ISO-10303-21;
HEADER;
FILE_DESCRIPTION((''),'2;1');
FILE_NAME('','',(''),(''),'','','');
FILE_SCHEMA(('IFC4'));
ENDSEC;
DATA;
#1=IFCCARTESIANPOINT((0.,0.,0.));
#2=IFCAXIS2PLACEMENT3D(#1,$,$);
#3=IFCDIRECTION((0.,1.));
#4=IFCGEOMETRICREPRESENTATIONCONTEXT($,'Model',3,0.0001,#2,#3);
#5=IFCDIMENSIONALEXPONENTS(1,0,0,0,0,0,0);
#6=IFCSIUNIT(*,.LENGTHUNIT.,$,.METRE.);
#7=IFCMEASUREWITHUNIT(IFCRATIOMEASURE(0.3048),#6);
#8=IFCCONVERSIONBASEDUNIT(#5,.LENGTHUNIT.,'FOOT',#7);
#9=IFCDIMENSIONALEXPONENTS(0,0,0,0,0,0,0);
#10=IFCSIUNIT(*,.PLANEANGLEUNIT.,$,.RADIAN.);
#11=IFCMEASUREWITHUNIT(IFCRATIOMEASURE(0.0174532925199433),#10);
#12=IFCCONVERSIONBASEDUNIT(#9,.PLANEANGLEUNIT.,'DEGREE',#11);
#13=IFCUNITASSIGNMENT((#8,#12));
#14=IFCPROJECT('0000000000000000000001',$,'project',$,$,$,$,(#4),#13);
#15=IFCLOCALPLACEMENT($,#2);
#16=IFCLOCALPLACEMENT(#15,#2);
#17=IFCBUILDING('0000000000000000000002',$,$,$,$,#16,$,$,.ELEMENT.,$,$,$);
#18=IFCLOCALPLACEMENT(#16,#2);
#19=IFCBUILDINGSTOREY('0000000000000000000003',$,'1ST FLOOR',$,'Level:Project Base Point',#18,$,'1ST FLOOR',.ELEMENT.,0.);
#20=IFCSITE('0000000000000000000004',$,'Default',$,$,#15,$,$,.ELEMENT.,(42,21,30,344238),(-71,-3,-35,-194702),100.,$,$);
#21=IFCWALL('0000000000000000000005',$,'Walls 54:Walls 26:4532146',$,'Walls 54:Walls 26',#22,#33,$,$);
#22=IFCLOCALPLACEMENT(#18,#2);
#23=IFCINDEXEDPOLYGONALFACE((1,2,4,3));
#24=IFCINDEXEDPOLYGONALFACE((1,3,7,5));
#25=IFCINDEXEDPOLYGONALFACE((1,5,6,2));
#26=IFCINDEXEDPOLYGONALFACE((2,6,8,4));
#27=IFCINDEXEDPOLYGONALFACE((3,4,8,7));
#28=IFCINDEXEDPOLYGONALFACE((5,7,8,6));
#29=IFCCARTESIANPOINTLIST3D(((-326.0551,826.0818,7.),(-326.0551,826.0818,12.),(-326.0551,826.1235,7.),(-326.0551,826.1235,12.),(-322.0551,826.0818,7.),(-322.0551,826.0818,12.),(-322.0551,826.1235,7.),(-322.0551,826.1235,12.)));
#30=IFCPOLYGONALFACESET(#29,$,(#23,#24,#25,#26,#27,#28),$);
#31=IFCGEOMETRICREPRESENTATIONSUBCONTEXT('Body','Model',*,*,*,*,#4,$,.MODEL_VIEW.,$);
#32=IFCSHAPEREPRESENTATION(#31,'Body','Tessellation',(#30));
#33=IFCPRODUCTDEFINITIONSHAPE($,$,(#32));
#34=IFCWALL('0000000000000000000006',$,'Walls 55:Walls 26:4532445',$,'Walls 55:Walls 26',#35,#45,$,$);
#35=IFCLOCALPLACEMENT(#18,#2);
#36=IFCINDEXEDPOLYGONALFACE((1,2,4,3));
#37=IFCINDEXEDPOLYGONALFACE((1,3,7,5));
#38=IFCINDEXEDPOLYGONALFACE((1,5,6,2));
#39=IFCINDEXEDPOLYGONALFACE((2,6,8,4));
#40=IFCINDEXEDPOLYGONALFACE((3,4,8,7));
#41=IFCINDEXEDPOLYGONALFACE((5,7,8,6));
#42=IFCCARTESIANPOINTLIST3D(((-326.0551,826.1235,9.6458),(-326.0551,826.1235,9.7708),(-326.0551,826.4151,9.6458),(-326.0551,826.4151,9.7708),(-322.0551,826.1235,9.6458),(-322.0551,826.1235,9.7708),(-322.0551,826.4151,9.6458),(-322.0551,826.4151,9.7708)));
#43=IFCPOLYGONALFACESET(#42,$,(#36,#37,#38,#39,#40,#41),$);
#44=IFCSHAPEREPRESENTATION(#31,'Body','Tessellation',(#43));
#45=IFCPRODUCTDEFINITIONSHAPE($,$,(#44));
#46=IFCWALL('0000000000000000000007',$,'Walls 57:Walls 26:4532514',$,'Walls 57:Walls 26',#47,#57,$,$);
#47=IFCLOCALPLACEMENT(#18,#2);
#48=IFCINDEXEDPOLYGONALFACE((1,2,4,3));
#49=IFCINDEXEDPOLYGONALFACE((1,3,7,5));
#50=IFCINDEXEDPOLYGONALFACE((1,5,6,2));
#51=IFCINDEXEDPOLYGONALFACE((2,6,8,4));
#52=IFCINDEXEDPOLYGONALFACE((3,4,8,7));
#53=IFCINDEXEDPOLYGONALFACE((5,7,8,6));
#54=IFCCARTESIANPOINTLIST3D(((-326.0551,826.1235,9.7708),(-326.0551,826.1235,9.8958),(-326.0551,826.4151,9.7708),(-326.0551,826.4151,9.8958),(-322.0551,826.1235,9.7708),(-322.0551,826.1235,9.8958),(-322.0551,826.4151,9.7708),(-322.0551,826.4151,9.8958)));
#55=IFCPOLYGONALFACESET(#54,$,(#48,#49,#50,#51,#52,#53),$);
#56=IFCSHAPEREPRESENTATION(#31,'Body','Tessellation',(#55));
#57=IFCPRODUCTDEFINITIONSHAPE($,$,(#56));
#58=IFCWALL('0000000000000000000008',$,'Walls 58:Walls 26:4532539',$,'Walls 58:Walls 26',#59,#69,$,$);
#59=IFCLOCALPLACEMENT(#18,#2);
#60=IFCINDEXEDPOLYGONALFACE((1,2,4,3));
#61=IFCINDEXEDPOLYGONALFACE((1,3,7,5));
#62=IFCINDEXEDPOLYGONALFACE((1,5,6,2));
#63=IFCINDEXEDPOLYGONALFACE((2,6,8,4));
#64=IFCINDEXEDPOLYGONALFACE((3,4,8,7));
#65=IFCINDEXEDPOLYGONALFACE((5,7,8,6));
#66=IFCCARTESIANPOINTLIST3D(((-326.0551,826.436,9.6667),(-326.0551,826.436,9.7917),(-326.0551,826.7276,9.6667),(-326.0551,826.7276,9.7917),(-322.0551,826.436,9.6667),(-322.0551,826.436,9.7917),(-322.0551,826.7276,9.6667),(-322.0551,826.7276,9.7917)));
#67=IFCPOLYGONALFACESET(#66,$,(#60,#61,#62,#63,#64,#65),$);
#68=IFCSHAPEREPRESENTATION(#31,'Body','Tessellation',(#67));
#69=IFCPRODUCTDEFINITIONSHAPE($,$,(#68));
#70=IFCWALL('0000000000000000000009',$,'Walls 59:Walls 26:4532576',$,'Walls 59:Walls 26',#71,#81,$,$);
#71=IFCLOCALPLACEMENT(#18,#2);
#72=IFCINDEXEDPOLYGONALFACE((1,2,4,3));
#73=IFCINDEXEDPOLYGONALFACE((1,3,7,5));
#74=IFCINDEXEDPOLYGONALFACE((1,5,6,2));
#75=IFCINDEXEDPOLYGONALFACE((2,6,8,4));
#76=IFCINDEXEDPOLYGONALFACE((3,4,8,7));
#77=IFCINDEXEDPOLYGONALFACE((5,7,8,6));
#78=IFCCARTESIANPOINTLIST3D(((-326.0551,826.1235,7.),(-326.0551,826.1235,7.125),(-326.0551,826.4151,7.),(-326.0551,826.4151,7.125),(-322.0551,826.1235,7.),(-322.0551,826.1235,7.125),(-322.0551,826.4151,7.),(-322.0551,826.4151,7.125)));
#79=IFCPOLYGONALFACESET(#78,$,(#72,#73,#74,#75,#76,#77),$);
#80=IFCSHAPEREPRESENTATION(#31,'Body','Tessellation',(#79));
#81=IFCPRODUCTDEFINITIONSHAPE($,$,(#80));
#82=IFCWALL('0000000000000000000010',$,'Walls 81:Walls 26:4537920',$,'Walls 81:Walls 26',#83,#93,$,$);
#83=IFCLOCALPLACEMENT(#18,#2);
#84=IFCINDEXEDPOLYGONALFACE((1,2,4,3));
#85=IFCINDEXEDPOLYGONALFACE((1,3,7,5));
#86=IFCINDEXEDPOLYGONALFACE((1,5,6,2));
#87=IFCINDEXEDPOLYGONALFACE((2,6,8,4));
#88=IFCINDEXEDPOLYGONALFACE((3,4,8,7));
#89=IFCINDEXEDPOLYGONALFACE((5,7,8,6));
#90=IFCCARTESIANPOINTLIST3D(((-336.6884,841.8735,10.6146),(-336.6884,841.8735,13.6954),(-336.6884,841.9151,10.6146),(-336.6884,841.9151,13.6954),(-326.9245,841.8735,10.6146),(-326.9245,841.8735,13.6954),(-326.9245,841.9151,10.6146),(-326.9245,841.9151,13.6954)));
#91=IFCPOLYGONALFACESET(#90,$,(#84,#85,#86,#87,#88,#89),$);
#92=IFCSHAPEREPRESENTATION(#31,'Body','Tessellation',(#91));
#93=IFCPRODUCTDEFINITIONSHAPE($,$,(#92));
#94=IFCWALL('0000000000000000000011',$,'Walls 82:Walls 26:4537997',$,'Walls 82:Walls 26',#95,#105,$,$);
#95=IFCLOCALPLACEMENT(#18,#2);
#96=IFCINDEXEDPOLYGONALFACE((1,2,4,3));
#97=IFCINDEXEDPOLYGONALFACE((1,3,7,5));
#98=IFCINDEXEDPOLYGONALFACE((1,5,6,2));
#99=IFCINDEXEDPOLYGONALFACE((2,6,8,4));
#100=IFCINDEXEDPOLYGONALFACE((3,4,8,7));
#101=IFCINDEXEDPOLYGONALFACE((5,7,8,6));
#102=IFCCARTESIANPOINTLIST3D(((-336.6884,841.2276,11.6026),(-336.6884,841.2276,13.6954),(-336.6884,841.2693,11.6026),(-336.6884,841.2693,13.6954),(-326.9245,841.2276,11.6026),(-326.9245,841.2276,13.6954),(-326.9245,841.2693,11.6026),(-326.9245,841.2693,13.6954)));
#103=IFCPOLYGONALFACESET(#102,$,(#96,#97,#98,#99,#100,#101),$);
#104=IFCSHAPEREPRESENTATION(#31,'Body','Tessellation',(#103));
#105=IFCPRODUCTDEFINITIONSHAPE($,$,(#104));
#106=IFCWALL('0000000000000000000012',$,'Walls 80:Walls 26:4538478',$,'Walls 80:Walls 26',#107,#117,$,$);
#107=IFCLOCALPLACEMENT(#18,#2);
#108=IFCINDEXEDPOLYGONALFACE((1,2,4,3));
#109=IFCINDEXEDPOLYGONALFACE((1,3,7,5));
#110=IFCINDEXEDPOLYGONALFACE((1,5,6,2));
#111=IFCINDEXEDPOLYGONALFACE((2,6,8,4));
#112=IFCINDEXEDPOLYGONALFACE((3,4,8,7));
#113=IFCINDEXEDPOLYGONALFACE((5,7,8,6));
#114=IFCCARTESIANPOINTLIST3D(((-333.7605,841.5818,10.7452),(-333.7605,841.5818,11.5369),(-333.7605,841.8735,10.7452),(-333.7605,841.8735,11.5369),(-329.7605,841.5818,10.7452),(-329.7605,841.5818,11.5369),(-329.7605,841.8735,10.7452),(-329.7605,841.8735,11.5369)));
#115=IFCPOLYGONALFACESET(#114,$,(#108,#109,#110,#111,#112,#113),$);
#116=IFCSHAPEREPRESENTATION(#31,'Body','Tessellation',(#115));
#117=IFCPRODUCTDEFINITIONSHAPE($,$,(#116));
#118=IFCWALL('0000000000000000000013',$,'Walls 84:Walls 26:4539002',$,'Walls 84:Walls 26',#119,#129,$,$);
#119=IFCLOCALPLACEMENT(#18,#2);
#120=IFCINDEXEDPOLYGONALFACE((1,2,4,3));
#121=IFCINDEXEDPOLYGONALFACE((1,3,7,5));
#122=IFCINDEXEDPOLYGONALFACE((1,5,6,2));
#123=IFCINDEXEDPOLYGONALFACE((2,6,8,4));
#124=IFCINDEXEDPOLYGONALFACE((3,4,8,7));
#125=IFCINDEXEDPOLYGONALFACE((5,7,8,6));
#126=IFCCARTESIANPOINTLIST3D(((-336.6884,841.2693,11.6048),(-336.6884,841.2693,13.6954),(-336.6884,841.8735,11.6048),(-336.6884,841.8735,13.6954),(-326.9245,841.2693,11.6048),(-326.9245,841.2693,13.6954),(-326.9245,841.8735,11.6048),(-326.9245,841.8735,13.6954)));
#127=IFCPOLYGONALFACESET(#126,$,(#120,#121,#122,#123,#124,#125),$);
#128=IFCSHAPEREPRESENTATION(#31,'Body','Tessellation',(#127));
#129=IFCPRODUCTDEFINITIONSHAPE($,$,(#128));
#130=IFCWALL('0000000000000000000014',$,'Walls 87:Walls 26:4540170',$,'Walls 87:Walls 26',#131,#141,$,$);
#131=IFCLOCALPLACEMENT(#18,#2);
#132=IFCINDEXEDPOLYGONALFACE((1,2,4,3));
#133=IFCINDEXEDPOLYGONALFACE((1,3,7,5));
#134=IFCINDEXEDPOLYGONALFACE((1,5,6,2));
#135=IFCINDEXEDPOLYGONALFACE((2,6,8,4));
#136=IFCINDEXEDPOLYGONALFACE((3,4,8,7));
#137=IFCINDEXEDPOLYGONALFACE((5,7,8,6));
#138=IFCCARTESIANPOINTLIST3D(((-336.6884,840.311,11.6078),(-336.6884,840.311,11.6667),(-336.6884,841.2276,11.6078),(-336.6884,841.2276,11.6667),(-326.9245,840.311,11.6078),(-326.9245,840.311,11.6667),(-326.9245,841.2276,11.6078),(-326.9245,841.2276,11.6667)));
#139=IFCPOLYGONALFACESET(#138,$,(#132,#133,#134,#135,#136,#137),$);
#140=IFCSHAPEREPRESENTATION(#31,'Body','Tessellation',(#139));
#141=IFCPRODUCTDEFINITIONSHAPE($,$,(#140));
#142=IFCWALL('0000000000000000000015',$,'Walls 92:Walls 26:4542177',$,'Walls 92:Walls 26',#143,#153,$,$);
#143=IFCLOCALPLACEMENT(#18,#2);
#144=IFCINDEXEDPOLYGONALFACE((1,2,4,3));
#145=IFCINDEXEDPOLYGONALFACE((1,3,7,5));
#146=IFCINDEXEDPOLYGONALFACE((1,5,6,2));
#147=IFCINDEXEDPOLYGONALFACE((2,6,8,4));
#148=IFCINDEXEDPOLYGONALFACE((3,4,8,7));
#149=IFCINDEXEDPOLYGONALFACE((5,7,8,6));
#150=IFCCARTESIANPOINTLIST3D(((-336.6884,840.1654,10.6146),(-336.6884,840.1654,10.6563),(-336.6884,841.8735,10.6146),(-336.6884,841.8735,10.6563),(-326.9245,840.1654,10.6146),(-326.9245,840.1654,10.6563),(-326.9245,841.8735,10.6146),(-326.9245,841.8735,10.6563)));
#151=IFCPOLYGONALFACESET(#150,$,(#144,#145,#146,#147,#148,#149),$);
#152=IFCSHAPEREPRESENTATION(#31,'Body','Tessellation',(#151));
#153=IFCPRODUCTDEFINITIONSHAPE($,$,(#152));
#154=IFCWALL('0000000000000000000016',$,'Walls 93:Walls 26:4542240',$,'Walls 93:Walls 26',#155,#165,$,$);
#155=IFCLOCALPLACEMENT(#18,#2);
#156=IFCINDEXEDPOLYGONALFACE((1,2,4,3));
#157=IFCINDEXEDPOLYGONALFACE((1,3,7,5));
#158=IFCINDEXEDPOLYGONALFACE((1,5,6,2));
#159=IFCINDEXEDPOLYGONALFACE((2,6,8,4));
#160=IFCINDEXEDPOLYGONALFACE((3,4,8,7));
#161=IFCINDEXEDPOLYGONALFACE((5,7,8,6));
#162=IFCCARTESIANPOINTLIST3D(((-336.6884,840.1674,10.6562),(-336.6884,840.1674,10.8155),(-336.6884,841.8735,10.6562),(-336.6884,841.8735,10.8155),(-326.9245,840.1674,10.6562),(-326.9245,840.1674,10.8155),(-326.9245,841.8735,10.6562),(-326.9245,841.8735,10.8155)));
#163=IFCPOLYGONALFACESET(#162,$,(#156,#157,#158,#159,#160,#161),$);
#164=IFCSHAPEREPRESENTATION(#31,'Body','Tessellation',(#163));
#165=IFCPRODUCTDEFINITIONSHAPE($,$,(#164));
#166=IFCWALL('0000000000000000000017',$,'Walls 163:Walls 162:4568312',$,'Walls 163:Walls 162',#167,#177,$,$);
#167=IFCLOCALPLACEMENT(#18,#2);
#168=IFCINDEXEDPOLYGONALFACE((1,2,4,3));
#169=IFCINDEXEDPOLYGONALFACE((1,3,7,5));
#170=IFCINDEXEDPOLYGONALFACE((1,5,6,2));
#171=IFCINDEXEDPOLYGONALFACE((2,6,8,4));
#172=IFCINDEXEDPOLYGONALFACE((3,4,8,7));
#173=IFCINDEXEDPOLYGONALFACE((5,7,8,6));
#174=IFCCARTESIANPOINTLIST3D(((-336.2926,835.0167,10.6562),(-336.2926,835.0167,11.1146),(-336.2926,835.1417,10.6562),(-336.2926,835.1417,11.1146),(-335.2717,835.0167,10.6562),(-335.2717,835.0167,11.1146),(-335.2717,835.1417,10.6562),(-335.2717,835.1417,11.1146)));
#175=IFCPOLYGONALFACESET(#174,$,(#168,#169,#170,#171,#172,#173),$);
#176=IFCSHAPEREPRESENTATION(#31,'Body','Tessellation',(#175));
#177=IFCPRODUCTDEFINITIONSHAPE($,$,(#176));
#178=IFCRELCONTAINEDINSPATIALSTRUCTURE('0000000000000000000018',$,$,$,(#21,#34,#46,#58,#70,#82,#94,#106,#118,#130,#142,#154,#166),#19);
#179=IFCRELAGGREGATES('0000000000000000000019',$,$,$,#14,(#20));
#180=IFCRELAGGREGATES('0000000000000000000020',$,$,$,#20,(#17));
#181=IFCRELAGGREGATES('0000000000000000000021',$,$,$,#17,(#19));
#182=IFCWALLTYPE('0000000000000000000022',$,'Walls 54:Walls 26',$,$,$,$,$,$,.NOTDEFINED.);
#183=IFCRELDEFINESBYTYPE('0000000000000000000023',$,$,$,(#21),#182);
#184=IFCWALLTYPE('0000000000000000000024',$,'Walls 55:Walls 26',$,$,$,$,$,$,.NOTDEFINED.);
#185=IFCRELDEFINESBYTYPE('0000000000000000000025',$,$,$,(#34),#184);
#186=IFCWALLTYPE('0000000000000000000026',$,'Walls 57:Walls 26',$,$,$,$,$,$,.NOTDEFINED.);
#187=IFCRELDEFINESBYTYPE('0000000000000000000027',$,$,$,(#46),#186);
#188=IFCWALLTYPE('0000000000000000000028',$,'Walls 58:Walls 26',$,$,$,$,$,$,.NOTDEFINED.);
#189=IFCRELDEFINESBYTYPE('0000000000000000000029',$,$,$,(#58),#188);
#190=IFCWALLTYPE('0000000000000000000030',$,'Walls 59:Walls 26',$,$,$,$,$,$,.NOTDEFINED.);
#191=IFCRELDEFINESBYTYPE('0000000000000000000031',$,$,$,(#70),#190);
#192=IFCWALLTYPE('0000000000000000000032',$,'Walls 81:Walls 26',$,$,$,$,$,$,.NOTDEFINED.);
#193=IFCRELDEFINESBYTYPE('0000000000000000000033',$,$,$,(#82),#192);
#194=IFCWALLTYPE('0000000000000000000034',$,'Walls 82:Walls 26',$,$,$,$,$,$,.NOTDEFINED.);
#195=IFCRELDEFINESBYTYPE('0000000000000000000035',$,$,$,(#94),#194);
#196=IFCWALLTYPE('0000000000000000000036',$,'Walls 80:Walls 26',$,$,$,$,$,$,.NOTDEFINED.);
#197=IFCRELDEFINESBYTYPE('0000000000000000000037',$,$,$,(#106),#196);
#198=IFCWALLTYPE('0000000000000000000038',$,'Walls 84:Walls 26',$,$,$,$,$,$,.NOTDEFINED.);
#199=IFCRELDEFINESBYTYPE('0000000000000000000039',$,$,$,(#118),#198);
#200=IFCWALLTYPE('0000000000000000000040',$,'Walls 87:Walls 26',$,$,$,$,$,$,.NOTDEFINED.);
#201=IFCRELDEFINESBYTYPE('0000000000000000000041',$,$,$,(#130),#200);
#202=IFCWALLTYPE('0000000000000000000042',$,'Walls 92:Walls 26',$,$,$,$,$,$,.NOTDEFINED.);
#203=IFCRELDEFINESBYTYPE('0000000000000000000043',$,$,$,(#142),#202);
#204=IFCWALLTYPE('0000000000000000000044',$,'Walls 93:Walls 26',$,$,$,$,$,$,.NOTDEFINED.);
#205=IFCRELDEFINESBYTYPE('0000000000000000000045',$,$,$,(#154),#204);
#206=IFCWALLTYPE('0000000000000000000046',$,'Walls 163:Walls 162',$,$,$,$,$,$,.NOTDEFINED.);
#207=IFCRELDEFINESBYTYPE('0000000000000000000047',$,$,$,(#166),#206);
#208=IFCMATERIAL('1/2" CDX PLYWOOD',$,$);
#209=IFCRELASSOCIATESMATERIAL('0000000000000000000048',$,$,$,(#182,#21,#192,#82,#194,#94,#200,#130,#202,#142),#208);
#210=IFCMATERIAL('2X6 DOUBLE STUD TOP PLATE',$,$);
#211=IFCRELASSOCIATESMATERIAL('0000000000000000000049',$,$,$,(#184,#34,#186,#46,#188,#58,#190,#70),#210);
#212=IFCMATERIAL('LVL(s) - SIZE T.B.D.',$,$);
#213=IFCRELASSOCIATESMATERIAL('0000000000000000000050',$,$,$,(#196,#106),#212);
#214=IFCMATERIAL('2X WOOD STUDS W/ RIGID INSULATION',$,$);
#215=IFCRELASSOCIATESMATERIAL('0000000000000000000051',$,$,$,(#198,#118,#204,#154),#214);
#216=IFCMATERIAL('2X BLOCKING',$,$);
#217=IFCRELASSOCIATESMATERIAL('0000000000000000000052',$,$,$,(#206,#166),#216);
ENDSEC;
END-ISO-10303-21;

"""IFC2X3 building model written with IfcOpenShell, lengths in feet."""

from ifc_helpers import new_model, entity, si_unit, converted_unit, direction, frame, frame_2d, origin, origin_2d_with_axis, place, context, subcontext, project, spatial, rectangle, extrude, material, type_object, element, save


model = new_model("IFC2X3")

# Units and contexts
model_context = context("Model", 3, precision=0.0001, world=origin(), true_north=direction((0.0, 1.0)))
body_context = subcontext(model_context, "Body", "Model", "MODEL_VIEW")
ifc_project = project(units=[converted_unit("LENGTHUNIT", "FOOT", entity("IfcRatioMeasure", 0.3048), si_unit("LENGTHUNIT", "METRE"), dimensions=[1, 0, 0, 0, 0, 0, 0]), converted_unit("PLANEANGLEUNIT", "DEGREE", entity("IfcRatioMeasure", 0.0174532925199433), si_unit("PLANEANGLEUNIT", "RADIAN"), dimensions=[0, 0, 0, 0, 0, 0, 0])], contexts=[model_context])

# Site, building, storey
site_placement = place(None, origin())
site = spatial("IfcSite", under=ifc_project, at=site_placement, Name="Default", CompositionType="ELEMENT", RefLatitude=(42, 21, 30, 344238), RefLongitude=(-71, -3, -35, -194702), RefElevation=100.0)
building_placement = place(site_placement, origin())
building = spatial("IfcBuilding", under=site, at=building_placement, CompositionType="ELEMENT")
storey_placement = place(building_placement, origin())
storey = spatial("IfcBuildingStorey", under=building, at=storey_placement, Name="1ST FLOOR", ObjectType="Level:Project Base Point", LongName="1ST FLOOR", CompositionType="ELEMENT", Elevation=0.0)

# Walls
ifc_material_1 = material(Name="1/2\" CDX PLYWOOD")
wall_type_1 = type_object("IfcWallType", Name="Walls 54:Walls 26", PredefinedType="NOTDEFINED", material=ifc_material_1)
wall_1_placement = place(storey_placement, frame((-326.0551, 826.0818, 7.0)))
element("IfcWall", 1, at=wall_1_placement, inside=storey, type_object=wall_type_1, material=ifc_material_1, Name="Walls 54:Walls 26:4532146", ObjectType="Walls 54:Walls 26", context=body_context, shape_type="SweptSolid", body=[
    extrude(rectangle(XDim=4.0, YDim=0.0417, at=frame_2d((0.0, 0.0), x_axis=(1.0, 0.0))), frame((2.0, 0.0208, 0.0), z_axis=(0.0, 0.0, 1.0), x_axis=(-1.0, 0.0, 0.0)), (0.0, 0.0, 1.0), 5.0),
])
ifc_material_2 = material(Name="2X6 DOUBLE STUD TOP PLATE")
wall_type_2 = type_object("IfcWallType", Name="Walls 55:Walls 26", PredefinedType="NOTDEFINED", material=ifc_material_2)
wall_2_placement = place(storey_placement, frame((-326.0551, 826.1235, 9.6458)))
element("IfcWall", 2, at=wall_2_placement, inside=storey, type_object=wall_type_2, material=ifc_material_2, Name="Walls 55:Walls 26:4532445", ObjectType="Walls 55:Walls 26", context=body_context, shape_type="SweptSolid", body=[
    extrude(rectangle(XDim=4.0, YDim=0.2917, at=origin_2d_with_axis()), frame((2.0, 0.1458, 0.0), z_axis=(0.0, 0.0, 1.0), x_axis=(-1.0, 0.0, 0.0)), (0.0, 0.0, 1.0), 0.125),
])
wall_type_3 = type_object("IfcWallType", Name="Walls 57:Walls 26", PredefinedType="NOTDEFINED", material=ifc_material_2)
wall_3_placement = place(storey_placement, frame((-326.0551, 826.1235, 9.7708)))
element("IfcWall", 3, at=wall_3_placement, inside=storey, type_object=wall_type_3, material=ifc_material_2, Name="Walls 57:Walls 26:4532514", ObjectType="Walls 57:Walls 26", context=body_context, shape_type="SweptSolid", body=[
    extrude(rectangle(XDim=4.0, YDim=0.2917, at=origin_2d_with_axis()), frame((2.0, 0.1458, 0.0), z_axis=(0.0, 0.0, 1.0), x_axis=(-1.0, 0.0, 0.0)), (0.0, 0.0, 1.0), 0.125),
])
wall_type_4 = type_object("IfcWallType", Name="Walls 58:Walls 26", PredefinedType="NOTDEFINED", material=ifc_material_2)
wall_4_placement = place(storey_placement, frame((-326.0551, 826.436, 9.6667)))
element("IfcWall", 4, at=wall_4_placement, inside=storey, type_object=wall_type_4, material=ifc_material_2, Name="Walls 58:Walls 26:4532539", ObjectType="Walls 58:Walls 26", context=body_context, shape_type="SweptSolid", body=[
    extrude(rectangle(XDim=4.0, YDim=0.2917, at=origin_2d_with_axis()), frame((2.0, 0.1458, 0.0), z_axis=(0.0, 0.0, 1.0), x_axis=(-1.0, 0.0, 0.0)), (0.0, 0.0, 1.0), 0.125),
])
wall_type_5 = type_object("IfcWallType", Name="Walls 59:Walls 26", PredefinedType="NOTDEFINED", material=ifc_material_2)
wall_5_placement = place(storey_placement, frame((-326.0551, 826.1235, 7.0)))
element("IfcWall", 5, at=wall_5_placement, inside=storey, type_object=wall_type_5, material=ifc_material_2, Name="Walls 59:Walls 26:4532576", ObjectType="Walls 59:Walls 26", context=body_context, shape_type="SweptSolid", body=[
    extrude(rectangle(XDim=4.0, YDim=0.2917, at=origin_2d_with_axis()), frame((2.0, 0.1458, 0.0), z_axis=(0.0, 0.0, 1.0), x_axis=(-1.0, 0.0, 0.0)), (0.0, 0.0, 1.0), 0.125),
])
wall_type_6 = type_object("IfcWallType", Name="Walls 81:Walls 26", PredefinedType="NOTDEFINED", material=ifc_material_1)
wall_6_placement = place(storey_placement, frame((-336.6884, 841.8735, 10.6146)))
element("IfcWall", 6, at=wall_6_placement, inside=storey, type_object=wall_type_6, material=ifc_material_1, Name="Walls 81:Walls 26:4537920", ObjectType="Walls 81:Walls 26", context=body_context, shape_type="SweptSolid", body=[
    extrude(rectangle(XDim=9.7639, YDim=0.0417, at=frame_2d((0.0, 0.0), x_axis=(1.0, 0.0))), frame((4.882, 0.0208, 0.0), z_axis=(0.0, 0.0, 1.0), x_axis=(-1.0, 0.0, 0.0)), (0.0, 0.0, 1.0), 3.0808),
])
wall_type_7 = type_object("IfcWallType", Name="Walls 82:Walls 26", PredefinedType="NOTDEFINED", material=ifc_material_1)
wall_7_placement = place(storey_placement, frame((-336.6884, 841.2276, 11.6026)))
element("IfcWall", 7, at=wall_7_placement, inside=storey, type_object=wall_type_7, material=ifc_material_1, Name="Walls 82:Walls 26:4537997", ObjectType="Walls 82:Walls 26", context=body_context, shape_type="SweptSolid", body=[
    extrude(rectangle(XDim=9.7639, YDim=0.0417, at=frame_2d((0.0, 0.0), x_axis=(1.0, 0.0))), frame((4.882, 0.0208, 0.0), z_axis=(0.0, 0.0, 1.0), x_axis=(-1.0, 0.0, 0.0)), (0.0, 0.0, 1.0), 2.0927),
])
ifc_material_3 = material(Name="LVL(s) - SIZE T.B.D.")
wall_type_8 = type_object("IfcWallType", Name="Walls 80:Walls 26", PredefinedType="NOTDEFINED", material=ifc_material_3)
wall_8_placement = place(storey_placement, frame((-333.7605, 841.5818, 10.7452)))
element("IfcWall", 8, at=wall_8_placement, inside=storey, type_object=wall_type_8, material=ifc_material_3, Name="Walls 80:Walls 26:4538478", ObjectType="Walls 80:Walls 26", context=body_context, shape_type="SweptSolid", body=[
    extrude(rectangle(XDim=4.0, YDim=0.2917, at=frame_2d((0.0, 0.0), x_axis=(1.0, 0.0))), frame((2.0, 0.1458, 0.0), z_axis=(0.0, 0.0, 1.0), x_axis=(-1.0, 0.0, 0.0)), (0.0, 0.0, 1.0), 0.7917),
])
ifc_material_4 = material(Name="2X WOOD STUDS W/ RIGID INSULATION")
wall_type_9 = type_object("IfcWallType", Name="Walls 84:Walls 26", PredefinedType="NOTDEFINED", material=ifc_material_4)
wall_9_placement = place(storey_placement, frame((-336.6884, 841.2693, 11.6048)))
element("IfcWall", 9, at=wall_9_placement, inside=storey, type_object=wall_type_9, material=ifc_material_4, Name="Walls 84:Walls 26:4539002", ObjectType="Walls 84:Walls 26", context=body_context, shape_type="SweptSolid", body=[
    extrude(rectangle(XDim=9.7639, YDim=0.6042, at=origin_2d_with_axis()), frame((4.882, 0.3021, 0.0), z_axis=(0.0, 0.0, 1.0), x_axis=(-1.0, 0.0, 0.0)), (0.0, 0.0, 1.0), 2.0906),
])
wall_type_10 = type_object("IfcWallType", Name="Walls 87:Walls 26", PredefinedType="NOTDEFINED", material=ifc_material_1)
wall_10_placement = place(storey_placement, frame((-336.6884, 840.311, 11.6078)))
element("IfcWall", 10, at=wall_10_placement, inside=storey, type_object=wall_type_10, material=ifc_material_1, Name="Walls 87:Walls 26:4540170", ObjectType="Walls 87:Walls 26", context=body_context, shape_type="SweptSolid", body=[
    extrude(rectangle(XDim=9.7639, YDim=0.9167, at=frame_2d((0.0, 0.0), x_axis=(1.0, 0.0))), frame((4.882, 0.4583, 0.0), z_axis=(0.0, 0.0, 1.0), x_axis=(-1.0, 0.0, 0.0)), (0.0, 0.0, 1.0), 0.0588),
])
wall_type_11 = type_object("IfcWallType", Name="Walls 92:Walls 26", PredefinedType="NOTDEFINED", material=ifc_material_1)
wall_11_placement = place(storey_placement, frame((-336.6884, 840.1654, 10.6146)))
element("IfcWall", 11, at=wall_11_placement, inside=storey, type_object=wall_type_11, material=ifc_material_1, Name="Walls 92:Walls 26:4542177", ObjectType="Walls 92:Walls 26", context=body_context, shape_type="SweptSolid", body=[
    extrude(rectangle(XDim=9.7639, YDim=1.708, at=origin_2d_with_axis()), frame((4.882, 0.854, 0.0), z_axis=(0.0, 0.0, 1.0), x_axis=(-1.0, 0.0, 0.0)), (0.0, 0.0, 1.0), 0.0417),
])
wall_type_12 = type_object("IfcWallType", Name="Walls 93:Walls 26", PredefinedType="NOTDEFINED", material=ifc_material_4)
wall_12_placement = place(storey_placement, frame((-336.6884, 840.1674, 10.6562)))
element("IfcWall", 12, at=wall_12_placement, inside=storey, type_object=wall_type_12, material=ifc_material_4, Name="Walls 93:Walls 26:4542240", ObjectType="Walls 93:Walls 26", context=body_context, shape_type="SweptSolid", body=[
    extrude(rectangle(XDim=9.7639, YDim=1.7061, at=origin_2d_with_axis()), frame((4.882, 0.853, 0.0), z_axis=(0.0, 0.0, 1.0), x_axis=(-1.0, 0.0, 0.0)), (0.0, 0.0, 1.0), 0.1593),
])
ifc_material_5 = material(Name="2X BLOCKING")
wall_type_13 = type_object("IfcWallType", Name="Walls 163:Walls 162", PredefinedType="NOTDEFINED", material=ifc_material_5)
wall_13_placement = place(storey_placement, frame((-336.2926, 835.0167, 10.6562)))
element("IfcWall", 13, at=wall_13_placement, inside=storey, type_object=wall_type_13, material=ifc_material_5, Name="Walls 163:Walls 162:4568312", ObjectType="Walls 163:Walls 162", context=body_context, shape_type="SweptSolid", body=[
    extrude(rectangle(XDim=1.0208, YDim=0.125, at=frame_2d((0.0, 0.0), x_axis=(1.0, 0.0))), frame((0.5104, 0.0625, 0.0), z_axis=(0.0, 0.0, 1.0), x_axis=(-1.0, 0.0, 0.0)), (0.0, 0.0, 1.0), 0.4583),
])

save(model, "model.ifc")
